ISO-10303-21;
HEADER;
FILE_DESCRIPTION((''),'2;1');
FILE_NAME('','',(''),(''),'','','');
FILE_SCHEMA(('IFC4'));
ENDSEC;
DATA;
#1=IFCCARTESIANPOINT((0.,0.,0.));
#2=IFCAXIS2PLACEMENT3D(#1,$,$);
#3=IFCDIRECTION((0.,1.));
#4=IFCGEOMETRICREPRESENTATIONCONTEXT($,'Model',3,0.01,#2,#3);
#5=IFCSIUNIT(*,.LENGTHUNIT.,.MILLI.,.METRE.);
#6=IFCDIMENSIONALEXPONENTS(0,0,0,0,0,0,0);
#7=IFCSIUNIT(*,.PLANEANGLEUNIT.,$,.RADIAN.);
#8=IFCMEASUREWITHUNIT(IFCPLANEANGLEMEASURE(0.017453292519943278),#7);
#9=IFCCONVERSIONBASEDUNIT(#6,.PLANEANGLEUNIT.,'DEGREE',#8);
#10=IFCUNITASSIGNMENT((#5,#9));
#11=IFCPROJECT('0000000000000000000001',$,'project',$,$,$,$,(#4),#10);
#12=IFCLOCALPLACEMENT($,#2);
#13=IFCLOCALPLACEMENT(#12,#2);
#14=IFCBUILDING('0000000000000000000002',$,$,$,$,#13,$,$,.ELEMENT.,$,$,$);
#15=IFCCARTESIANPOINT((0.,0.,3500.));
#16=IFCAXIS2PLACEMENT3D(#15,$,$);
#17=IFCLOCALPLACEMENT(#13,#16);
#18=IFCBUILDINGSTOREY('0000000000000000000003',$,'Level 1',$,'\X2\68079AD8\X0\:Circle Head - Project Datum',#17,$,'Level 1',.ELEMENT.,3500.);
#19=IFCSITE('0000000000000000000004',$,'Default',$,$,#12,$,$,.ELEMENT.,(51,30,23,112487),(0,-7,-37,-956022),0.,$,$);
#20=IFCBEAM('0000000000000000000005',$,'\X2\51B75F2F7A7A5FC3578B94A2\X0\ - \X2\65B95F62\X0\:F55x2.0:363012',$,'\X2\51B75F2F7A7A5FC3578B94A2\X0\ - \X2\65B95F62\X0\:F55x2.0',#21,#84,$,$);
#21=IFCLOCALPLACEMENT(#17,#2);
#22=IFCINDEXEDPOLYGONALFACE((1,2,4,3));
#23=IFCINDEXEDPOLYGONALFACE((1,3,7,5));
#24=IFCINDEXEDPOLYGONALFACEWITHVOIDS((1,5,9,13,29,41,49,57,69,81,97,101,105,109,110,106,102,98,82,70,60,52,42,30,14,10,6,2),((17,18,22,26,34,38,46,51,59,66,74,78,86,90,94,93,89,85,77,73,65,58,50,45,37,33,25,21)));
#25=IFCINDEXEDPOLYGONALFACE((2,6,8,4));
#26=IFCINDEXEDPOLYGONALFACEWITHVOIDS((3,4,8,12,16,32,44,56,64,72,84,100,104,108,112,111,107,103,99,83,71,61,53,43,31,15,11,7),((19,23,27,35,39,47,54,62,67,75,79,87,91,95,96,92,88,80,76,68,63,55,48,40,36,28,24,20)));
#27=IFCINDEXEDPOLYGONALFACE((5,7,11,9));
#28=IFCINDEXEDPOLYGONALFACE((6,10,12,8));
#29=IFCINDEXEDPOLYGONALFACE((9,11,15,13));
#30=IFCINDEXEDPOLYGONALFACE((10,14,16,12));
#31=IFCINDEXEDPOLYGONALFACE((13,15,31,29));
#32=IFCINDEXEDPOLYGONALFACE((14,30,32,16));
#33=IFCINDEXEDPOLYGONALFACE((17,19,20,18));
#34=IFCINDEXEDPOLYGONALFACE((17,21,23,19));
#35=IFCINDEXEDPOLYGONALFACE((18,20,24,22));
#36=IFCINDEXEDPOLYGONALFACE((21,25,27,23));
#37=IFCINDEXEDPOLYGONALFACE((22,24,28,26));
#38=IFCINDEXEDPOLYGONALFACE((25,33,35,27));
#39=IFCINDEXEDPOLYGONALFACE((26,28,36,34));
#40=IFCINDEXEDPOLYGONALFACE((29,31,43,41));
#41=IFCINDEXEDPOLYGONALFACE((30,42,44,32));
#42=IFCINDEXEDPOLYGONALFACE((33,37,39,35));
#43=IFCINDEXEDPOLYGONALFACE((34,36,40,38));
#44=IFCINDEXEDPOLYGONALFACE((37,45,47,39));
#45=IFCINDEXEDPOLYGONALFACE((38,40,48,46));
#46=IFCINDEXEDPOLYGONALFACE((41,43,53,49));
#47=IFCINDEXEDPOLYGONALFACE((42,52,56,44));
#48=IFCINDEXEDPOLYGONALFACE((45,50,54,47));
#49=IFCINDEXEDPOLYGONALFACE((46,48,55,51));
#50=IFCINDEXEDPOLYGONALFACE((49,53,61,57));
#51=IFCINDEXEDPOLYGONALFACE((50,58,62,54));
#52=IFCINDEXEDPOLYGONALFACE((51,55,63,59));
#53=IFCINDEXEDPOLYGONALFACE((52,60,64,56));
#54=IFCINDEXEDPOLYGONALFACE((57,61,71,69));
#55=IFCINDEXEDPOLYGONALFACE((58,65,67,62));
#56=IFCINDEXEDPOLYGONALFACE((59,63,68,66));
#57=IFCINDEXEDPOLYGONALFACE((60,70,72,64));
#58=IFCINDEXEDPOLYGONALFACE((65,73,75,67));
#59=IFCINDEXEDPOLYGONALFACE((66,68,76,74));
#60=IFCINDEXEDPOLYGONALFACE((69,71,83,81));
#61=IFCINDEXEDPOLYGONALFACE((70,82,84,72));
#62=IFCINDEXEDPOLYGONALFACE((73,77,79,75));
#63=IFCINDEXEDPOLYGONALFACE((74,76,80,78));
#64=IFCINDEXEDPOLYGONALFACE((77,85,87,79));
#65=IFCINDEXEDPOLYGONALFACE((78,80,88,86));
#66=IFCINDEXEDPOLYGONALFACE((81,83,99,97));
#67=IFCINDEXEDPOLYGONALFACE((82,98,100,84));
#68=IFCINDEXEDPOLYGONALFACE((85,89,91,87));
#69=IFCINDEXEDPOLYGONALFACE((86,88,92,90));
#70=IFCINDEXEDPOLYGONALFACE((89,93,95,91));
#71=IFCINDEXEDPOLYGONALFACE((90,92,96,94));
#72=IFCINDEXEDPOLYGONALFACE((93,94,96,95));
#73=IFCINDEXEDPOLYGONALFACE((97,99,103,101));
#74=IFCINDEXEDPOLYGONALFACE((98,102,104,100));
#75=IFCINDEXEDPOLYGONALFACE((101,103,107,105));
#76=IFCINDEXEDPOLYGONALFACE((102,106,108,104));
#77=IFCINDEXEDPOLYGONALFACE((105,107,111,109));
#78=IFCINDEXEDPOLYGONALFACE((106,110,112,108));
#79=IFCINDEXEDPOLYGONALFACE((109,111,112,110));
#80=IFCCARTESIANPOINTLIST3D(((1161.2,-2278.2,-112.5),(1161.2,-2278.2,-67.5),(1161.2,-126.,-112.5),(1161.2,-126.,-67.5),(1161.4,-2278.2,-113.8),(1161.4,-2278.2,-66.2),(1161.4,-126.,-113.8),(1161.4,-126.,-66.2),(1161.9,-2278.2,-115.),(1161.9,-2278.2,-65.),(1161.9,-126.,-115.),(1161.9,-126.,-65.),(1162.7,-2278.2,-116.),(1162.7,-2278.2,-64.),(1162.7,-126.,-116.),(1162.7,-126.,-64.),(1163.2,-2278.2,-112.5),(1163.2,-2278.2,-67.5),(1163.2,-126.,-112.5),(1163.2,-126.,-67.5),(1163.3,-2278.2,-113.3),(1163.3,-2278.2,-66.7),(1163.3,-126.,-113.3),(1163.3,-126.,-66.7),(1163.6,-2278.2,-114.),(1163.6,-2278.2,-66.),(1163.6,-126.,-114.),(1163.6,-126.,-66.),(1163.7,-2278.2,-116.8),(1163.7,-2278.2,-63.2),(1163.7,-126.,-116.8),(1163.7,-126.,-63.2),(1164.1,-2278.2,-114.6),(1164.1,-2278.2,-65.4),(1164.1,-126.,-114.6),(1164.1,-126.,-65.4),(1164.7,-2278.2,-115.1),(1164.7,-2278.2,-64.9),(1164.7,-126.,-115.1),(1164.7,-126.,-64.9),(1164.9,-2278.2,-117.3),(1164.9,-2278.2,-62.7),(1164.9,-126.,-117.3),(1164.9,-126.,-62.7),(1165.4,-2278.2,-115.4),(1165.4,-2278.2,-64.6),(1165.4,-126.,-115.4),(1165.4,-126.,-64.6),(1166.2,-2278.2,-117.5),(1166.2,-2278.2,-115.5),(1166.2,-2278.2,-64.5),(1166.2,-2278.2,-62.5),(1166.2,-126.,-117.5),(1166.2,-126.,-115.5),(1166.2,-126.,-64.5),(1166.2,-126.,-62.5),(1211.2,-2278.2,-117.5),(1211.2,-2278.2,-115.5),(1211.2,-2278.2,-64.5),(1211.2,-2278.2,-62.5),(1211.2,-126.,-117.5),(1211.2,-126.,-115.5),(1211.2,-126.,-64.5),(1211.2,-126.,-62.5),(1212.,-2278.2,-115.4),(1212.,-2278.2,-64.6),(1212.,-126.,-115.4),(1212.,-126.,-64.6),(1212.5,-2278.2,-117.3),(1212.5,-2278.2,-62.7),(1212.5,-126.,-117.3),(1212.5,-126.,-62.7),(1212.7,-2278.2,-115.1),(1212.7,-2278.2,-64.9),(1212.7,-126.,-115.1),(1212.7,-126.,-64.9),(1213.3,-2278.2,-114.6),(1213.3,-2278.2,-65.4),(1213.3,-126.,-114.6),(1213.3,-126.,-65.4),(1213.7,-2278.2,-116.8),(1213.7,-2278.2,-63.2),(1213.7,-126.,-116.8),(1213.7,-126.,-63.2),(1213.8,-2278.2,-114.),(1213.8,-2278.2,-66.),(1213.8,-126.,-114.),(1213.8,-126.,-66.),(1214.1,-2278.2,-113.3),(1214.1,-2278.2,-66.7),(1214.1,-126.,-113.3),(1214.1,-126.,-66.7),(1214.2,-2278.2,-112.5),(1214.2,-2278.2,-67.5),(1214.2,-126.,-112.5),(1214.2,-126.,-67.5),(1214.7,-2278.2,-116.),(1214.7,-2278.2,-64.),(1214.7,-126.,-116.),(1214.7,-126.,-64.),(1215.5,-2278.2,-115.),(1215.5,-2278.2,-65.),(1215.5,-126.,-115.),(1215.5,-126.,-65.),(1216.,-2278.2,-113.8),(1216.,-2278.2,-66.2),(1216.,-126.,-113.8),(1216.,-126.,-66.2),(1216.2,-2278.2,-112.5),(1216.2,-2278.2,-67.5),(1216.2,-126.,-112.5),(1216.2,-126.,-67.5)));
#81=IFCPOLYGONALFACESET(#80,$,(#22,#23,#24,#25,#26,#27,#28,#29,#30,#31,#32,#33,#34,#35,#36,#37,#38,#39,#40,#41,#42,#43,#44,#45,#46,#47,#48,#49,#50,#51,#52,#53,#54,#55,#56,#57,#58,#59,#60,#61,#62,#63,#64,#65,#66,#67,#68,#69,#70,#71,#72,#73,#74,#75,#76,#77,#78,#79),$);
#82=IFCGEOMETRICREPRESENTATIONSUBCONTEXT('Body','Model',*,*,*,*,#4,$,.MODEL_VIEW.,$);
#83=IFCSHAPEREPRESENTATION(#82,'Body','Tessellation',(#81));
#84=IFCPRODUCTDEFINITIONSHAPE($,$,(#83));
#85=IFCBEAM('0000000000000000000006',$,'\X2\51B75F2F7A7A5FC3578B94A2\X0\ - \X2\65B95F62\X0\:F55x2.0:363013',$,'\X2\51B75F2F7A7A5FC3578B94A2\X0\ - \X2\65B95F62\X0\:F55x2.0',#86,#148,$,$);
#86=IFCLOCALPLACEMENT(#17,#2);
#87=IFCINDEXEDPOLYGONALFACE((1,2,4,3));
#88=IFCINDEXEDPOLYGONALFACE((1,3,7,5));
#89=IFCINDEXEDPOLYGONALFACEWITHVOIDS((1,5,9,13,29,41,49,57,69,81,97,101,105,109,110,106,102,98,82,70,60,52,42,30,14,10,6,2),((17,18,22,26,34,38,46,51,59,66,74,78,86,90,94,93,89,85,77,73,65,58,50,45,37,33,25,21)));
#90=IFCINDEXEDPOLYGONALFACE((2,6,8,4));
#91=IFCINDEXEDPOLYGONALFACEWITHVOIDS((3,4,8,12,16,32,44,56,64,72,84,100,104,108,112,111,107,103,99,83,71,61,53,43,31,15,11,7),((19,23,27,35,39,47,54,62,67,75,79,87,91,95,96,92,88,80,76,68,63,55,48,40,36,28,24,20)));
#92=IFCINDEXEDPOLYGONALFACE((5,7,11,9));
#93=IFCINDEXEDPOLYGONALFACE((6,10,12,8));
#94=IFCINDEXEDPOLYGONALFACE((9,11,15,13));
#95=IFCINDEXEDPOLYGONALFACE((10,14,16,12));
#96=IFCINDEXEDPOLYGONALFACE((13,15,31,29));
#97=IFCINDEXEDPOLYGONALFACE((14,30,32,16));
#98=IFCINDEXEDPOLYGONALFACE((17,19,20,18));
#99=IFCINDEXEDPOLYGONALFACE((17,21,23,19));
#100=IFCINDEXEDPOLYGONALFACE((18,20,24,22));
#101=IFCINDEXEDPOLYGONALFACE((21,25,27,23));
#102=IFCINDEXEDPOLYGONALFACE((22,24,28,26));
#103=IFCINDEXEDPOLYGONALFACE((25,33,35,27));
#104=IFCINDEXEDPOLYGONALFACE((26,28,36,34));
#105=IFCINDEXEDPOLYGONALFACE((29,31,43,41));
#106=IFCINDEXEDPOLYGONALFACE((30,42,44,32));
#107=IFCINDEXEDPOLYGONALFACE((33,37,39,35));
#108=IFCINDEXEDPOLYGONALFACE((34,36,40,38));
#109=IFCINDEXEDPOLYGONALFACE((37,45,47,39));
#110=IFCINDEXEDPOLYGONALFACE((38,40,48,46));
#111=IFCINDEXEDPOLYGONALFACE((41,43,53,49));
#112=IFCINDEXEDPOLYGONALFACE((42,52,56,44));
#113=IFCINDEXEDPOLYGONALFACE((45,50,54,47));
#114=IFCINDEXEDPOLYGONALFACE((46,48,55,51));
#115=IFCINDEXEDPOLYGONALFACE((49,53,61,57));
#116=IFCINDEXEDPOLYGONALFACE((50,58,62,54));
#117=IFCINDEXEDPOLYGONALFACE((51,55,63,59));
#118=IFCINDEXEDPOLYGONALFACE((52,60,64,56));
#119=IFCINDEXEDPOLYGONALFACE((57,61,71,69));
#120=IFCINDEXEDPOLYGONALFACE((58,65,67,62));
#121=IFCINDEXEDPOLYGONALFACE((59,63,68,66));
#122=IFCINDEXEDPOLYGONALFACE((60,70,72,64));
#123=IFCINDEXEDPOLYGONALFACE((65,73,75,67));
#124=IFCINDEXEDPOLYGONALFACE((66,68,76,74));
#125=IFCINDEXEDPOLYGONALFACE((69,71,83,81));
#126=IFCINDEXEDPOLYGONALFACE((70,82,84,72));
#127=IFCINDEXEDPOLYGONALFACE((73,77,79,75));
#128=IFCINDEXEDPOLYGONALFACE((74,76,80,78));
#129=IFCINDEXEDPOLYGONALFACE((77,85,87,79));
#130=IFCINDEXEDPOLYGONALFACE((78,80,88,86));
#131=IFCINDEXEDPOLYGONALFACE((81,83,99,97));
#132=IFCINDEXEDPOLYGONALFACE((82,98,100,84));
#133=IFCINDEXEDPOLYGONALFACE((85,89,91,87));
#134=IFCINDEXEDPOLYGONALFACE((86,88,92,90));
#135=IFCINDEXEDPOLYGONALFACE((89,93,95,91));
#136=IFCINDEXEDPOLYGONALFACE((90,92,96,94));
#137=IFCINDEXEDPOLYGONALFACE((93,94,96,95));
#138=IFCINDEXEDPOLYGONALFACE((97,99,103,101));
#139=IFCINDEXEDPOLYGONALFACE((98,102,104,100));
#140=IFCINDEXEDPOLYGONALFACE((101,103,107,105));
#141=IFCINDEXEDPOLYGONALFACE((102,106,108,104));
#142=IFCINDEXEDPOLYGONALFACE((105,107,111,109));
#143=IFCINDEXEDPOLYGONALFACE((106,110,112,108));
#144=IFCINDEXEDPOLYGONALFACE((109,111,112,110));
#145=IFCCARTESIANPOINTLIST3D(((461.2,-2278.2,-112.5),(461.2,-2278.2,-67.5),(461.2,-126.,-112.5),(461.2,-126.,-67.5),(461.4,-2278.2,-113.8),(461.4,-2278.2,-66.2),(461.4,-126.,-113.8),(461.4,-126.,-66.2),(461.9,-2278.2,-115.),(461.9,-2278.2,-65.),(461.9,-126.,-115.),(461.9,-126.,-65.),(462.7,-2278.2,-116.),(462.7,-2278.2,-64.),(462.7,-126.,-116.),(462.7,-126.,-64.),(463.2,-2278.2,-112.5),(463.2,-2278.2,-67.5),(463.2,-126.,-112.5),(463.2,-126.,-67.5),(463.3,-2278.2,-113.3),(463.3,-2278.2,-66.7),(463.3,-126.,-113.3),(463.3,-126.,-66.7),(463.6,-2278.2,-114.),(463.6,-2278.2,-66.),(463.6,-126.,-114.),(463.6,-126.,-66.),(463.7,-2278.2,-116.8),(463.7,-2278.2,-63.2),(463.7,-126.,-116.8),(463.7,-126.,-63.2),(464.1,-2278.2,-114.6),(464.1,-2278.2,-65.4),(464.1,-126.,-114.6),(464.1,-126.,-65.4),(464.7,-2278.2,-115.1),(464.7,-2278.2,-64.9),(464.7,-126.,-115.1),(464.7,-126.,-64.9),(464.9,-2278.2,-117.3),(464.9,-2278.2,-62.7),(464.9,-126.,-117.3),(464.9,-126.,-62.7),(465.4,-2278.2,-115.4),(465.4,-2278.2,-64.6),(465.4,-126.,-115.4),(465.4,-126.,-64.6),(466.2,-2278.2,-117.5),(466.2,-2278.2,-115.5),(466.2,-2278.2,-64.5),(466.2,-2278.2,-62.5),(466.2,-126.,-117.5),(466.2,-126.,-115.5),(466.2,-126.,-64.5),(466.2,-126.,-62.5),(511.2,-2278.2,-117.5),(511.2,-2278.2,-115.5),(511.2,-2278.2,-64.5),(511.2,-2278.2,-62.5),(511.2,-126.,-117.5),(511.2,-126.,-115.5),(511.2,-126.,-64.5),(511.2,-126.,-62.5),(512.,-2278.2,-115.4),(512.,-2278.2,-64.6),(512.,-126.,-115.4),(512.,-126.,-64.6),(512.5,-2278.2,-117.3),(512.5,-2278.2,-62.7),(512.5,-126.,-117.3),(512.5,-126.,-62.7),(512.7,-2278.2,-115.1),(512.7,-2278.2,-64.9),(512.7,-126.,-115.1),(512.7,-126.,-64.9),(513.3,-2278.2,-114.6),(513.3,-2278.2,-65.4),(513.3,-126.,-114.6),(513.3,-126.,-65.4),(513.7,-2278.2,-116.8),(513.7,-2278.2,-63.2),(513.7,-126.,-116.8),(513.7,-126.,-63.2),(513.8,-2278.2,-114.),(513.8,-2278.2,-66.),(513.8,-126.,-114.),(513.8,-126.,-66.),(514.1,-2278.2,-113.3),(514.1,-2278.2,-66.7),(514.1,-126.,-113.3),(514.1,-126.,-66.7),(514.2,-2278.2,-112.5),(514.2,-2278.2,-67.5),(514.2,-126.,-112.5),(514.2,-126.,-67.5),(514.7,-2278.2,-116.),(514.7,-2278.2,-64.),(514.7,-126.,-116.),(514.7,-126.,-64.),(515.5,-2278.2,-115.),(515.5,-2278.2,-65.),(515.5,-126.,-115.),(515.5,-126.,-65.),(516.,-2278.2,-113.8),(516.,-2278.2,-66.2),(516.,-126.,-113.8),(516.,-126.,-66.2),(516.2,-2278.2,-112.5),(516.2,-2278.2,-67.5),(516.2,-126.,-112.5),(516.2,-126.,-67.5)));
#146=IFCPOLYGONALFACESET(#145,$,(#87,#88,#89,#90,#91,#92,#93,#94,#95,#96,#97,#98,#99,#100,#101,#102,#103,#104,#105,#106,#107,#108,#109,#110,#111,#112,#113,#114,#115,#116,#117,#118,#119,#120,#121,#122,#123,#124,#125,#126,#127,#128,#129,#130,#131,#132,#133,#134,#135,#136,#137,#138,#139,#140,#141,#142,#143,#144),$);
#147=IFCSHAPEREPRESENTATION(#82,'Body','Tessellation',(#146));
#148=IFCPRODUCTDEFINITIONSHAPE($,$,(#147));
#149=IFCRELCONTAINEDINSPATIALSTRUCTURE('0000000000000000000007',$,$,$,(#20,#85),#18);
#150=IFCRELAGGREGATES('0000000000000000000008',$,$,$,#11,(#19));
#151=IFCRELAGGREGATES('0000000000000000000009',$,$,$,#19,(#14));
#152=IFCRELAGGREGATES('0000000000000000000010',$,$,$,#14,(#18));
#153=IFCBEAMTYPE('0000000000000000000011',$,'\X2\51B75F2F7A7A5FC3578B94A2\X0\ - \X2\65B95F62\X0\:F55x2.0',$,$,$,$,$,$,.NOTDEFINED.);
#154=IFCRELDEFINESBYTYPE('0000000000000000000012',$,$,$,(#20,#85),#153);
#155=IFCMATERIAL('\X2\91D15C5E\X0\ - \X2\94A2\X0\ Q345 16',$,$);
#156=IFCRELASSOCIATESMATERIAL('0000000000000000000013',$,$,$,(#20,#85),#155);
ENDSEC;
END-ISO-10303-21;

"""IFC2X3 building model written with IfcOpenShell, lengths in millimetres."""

from ifc_helpers import new_model, entity, si_unit, converted_unit, direction, frame, frame_2d, origin, place, context, subcontext, project, spatial, polyline, circle_curve, parameter, trimmed, segment, composite_curve, outline, extrude, material, type_object, element, save


model = new_model("IFC2X3")

# Units and contexts
model_context = context("Model", 3, precision=0.01, world=origin(), true_north=direction((0.0, 1.0)))
body_context = subcontext(model_context, "Body", "Model", "MODEL_VIEW")
ifc_project = project(units=[si_unit("LENGTHUNIT", "METRE", prefix="MILLI"), converted_unit("PLANEANGLEUNIT", "DEGREE", entity("IfcPlaneAngleMeasure", 0.017453292519943278), si_unit("PLANEANGLEUNIT", "RADIAN"), dimensions=[0, 0, 0, 0, 0, 0, 0])], contexts=[model_context])

# Site, building, storey
site_placement = place(None, origin())
site = spatial("IfcSite", under=ifc_project, at=site_placement, Name="Default", CompositionType="ELEMENT", RefLatitude=(51, 30, 23, 112487), RefLongitude=(0, -7, -37, -956022), RefElevation=0.0)
building_placement = place(site_placement, origin())
building = spatial("IfcBuilding", under=site, at=building_placement, CompositionType="ELEMENT")
storey_placement = place(building_placement, frame((0.0, 0.0, 3500.0)))
storey = spatial("IfcBuildingStorey", under=building, at=storey_placement, Name="Level 1", ObjectType="标高:Circle Head - Project Datum", LongName="Level 1", CompositionType="ELEMENT", Elevation=3500.0)

# Beams
ifc_material_1 = material(Name="金属 - 钢 Q345 16")
beam_type_1 = type_object("IfcBeamType", Name="冷弯空心型钢 - 方形:F55x2.0", PredefinedType="NOTDEFINED")
beam_1_placement = place(storey_placement, frame((1188.7, -390.5, -62.5), z_axis=(0.0, 0.0, 1.0), x_axis=(0.0, -1.0, 0.0)))
element("IfcBeam", 1, at=beam_1_placement, inside=storey, type_object=beam_type_1, material=ifc_material_1, Name="冷弯空心型钢 - 方形:F55x2.0:363012", ObjectType="冷弯空心型钢 - 方形:F55x2.0", context=body_context, shape_type="SweptSolid", body=[
    extrude(outline(composite_curve([segment(trimmed(circle_curve(frame_2d((-22.5, 22.5), x_axis=(1.0, 0.0)), 5.0), [parameter(90.0)], [parameter(180.0)], True, "PARAMETER"), True, "CONTINUOUS"), segment(polyline([(-27.5, 22.5), (-27.5, -22.5)]), True, "CONTINUOUS"), segment(trimmed(circle_curve(frame_2d((-22.5, -22.5), x_axis=(1.0, 0.0)), 5.0), [parameter(180.0)], [parameter(270.0)], True, "PARAMETER"), True, "CONTINUOUS"), segment(polyline([(-22.5, -27.5), (22.5, -27.5)]), True, "CONTINUOUS"), segment(trimmed(circle_curve(frame_2d((22.5, -22.5), x_axis=(1.0, 0.0)), 5.0), [parameter(270.0)], [parameter(0.0)], True, "PARAMETER"), True, "CONTINUOUS"), segment(polyline([(27.5, -22.5), (27.5, 22.5)]), True, "CONTINUOUS"), segment(trimmed(circle_curve(frame_2d((22.5, 22.5), x_axis=(1.0, 0.0)), 5.0), [parameter(0.0)], [parameter(90.0)], True, "PARAMETER"), True, "CONTINUOUS"), segment(polyline([(22.5, 27.5), (-22.5, 27.5)]), True, "CONTINUOUS")], self_intersect=False), holes=[composite_curve([segment(polyline([(-22.5, 25.5), (22.5, 25.5)]), True, "CONTINUOUS"), segment(trimmed(circle_curve(frame_2d((22.5, 22.5), x_axis=(1.0, 0.0)), 3.0), [parameter(0.0)], [parameter(90.0)], True, "PARAMETER"), False, "CONTINUOUS"), segment(polyline([(25.5, 22.5), (25.5, -22.5)]), True, "CONTINUOUS"), segment(trimmed(circle_curve(frame_2d((22.5, -22.5), x_axis=(1.0, 0.0)), 3.0), [parameter(270.0)], [parameter(360.0)], True, "PARAMETER"), False, "CONTINUOUS"), segment(polyline([(22.5, -25.5), (-22.5, -25.5)]), True, "CONTINUOUS"), segment(trimmed(circle_curve(frame_2d((-22.5, -22.5), x_axis=(1.0, 0.0)), 3.0), [parameter(180.0)], [parameter(270.0)], True, "PARAMETER"), False, "CONTINUOUS"), segment(polyline([(-25.5, -22.5), (-25.5, 22.5)]), True, "CONTINUOUS"), segment(trimmed(circle_curve(frame_2d((-22.5, 22.5), x_axis=(1.0, 0.0)), 3.0), [parameter(90.0)], [parameter(180.0)], True, "PARAMETER"), False, "CONTINUOUS")], self_intersect=False)]), frame((-264.5, 0.0, -27.5), z_axis=(1.0, 0.0, 0.0), x_axis=(0.0, 1.0, 0.0)), (0.0, 0.0, 1.0), 2152.2),
])
beam_2_placement = place(storey_placement, frame((488.7, -390.5, -62.5), z_axis=(0.0, 0.0, 1.0), x_axis=(0.0, -1.0, 0.0)))
element("IfcBeam", 2, at=beam_2_placement, inside=storey, type_object=beam_type_1, material=ifc_material_1, Name="冷弯空心型钢 - 方形:F55x2.0:363013", ObjectType="冷弯空心型钢 - 方形:F55x2.0", context=body_context, shape_type="SweptSolid", body=[
    extrude(outline(composite_curve([segment(trimmed(circle_curve(frame_2d((-22.5, 22.5), x_axis=(1.0, 0.0)), 5.0), [parameter(90.0)], [parameter(180.0)], True, "PARAMETER"), True, "CONTINUOUS"), segment(polyline([(-27.5, 22.5), (-27.5, -22.5)]), True, "CONTINUOUS"), segment(trimmed(circle_curve(frame_2d((-22.5, -22.5), x_axis=(1.0, 0.0)), 5.0), [parameter(180.0)], [parameter(270.0)], True, "PARAMETER"), True, "CONTINUOUS"), segment(polyline([(-22.5, -27.5), (22.5, -27.5)]), True, "CONTINUOUS"), segment(trimmed(circle_curve(frame_2d((22.5, -22.5), x_axis=(1.0, 0.0)), 5.0), [parameter(270.0)], [parameter(0.0)], True, "PARAMETER"), True, "CONTINUOUS"), segment(polyline([(27.5, -22.5), (27.5, 22.5)]), True, "CONTINUOUS"), segment(trimmed(circle_curve(frame_2d((22.5, 22.5), x_axis=(1.0, 0.0)), 5.0), [parameter(0.0)], [parameter(90.0)], True, "PARAMETER"), True, "CONTINUOUS"), segment(polyline([(22.5, 27.5), (-22.5, 27.5)]), True, "CONTINUOUS")], self_intersect=False), holes=[composite_curve([segment(polyline([(-22.5, 25.5), (22.5, 25.5)]), True, "CONTINUOUS"), segment(trimmed(circle_curve(frame_2d((22.5, 22.5), x_axis=(1.0, 0.0)), 3.0), [parameter(0.0)], [parameter(90.0)], True, "PARAMETER"), False, "CONTINUOUS"), segment(polyline([(25.5, 22.5), (25.5, -22.5)]), True, "CONTINUOUS"), segment(trimmed(circle_curve(frame_2d((22.5, -22.5), x_axis=(1.0, 0.0)), 3.0), [parameter(270.0)], [parameter(360.0)], True, "PARAMETER"), False, "CONTINUOUS"), segment(polyline([(22.5, -25.5), (-22.5, -25.5)]), True, "CONTINUOUS"), segment(trimmed(circle_curve(frame_2d((-22.5, -22.5), x_axis=(1.0, 0.0)), 3.0), [parameter(180.0)], [parameter(270.0)], True, "PARAMETER"), False, "CONTINUOUS"), segment(polyline([(-25.5, -22.5), (-25.5, 22.5)]), True, "CONTINUOUS"), segment(trimmed(circle_curve(frame_2d((-22.5, 22.5), x_axis=(1.0, 0.0)), 3.0), [parameter(90.0)], [parameter(180.0)], True, "PARAMETER"), False, "CONTINUOUS")], self_intersect=False)]), frame((-264.5, 0.0, -27.5), z_axis=(1.0, 0.0, 0.0), x_axis=(0.0, 1.0, 0.0)), (0.0, 0.0, 1.0), 2152.2),
])

save(model, "model.ifc")
